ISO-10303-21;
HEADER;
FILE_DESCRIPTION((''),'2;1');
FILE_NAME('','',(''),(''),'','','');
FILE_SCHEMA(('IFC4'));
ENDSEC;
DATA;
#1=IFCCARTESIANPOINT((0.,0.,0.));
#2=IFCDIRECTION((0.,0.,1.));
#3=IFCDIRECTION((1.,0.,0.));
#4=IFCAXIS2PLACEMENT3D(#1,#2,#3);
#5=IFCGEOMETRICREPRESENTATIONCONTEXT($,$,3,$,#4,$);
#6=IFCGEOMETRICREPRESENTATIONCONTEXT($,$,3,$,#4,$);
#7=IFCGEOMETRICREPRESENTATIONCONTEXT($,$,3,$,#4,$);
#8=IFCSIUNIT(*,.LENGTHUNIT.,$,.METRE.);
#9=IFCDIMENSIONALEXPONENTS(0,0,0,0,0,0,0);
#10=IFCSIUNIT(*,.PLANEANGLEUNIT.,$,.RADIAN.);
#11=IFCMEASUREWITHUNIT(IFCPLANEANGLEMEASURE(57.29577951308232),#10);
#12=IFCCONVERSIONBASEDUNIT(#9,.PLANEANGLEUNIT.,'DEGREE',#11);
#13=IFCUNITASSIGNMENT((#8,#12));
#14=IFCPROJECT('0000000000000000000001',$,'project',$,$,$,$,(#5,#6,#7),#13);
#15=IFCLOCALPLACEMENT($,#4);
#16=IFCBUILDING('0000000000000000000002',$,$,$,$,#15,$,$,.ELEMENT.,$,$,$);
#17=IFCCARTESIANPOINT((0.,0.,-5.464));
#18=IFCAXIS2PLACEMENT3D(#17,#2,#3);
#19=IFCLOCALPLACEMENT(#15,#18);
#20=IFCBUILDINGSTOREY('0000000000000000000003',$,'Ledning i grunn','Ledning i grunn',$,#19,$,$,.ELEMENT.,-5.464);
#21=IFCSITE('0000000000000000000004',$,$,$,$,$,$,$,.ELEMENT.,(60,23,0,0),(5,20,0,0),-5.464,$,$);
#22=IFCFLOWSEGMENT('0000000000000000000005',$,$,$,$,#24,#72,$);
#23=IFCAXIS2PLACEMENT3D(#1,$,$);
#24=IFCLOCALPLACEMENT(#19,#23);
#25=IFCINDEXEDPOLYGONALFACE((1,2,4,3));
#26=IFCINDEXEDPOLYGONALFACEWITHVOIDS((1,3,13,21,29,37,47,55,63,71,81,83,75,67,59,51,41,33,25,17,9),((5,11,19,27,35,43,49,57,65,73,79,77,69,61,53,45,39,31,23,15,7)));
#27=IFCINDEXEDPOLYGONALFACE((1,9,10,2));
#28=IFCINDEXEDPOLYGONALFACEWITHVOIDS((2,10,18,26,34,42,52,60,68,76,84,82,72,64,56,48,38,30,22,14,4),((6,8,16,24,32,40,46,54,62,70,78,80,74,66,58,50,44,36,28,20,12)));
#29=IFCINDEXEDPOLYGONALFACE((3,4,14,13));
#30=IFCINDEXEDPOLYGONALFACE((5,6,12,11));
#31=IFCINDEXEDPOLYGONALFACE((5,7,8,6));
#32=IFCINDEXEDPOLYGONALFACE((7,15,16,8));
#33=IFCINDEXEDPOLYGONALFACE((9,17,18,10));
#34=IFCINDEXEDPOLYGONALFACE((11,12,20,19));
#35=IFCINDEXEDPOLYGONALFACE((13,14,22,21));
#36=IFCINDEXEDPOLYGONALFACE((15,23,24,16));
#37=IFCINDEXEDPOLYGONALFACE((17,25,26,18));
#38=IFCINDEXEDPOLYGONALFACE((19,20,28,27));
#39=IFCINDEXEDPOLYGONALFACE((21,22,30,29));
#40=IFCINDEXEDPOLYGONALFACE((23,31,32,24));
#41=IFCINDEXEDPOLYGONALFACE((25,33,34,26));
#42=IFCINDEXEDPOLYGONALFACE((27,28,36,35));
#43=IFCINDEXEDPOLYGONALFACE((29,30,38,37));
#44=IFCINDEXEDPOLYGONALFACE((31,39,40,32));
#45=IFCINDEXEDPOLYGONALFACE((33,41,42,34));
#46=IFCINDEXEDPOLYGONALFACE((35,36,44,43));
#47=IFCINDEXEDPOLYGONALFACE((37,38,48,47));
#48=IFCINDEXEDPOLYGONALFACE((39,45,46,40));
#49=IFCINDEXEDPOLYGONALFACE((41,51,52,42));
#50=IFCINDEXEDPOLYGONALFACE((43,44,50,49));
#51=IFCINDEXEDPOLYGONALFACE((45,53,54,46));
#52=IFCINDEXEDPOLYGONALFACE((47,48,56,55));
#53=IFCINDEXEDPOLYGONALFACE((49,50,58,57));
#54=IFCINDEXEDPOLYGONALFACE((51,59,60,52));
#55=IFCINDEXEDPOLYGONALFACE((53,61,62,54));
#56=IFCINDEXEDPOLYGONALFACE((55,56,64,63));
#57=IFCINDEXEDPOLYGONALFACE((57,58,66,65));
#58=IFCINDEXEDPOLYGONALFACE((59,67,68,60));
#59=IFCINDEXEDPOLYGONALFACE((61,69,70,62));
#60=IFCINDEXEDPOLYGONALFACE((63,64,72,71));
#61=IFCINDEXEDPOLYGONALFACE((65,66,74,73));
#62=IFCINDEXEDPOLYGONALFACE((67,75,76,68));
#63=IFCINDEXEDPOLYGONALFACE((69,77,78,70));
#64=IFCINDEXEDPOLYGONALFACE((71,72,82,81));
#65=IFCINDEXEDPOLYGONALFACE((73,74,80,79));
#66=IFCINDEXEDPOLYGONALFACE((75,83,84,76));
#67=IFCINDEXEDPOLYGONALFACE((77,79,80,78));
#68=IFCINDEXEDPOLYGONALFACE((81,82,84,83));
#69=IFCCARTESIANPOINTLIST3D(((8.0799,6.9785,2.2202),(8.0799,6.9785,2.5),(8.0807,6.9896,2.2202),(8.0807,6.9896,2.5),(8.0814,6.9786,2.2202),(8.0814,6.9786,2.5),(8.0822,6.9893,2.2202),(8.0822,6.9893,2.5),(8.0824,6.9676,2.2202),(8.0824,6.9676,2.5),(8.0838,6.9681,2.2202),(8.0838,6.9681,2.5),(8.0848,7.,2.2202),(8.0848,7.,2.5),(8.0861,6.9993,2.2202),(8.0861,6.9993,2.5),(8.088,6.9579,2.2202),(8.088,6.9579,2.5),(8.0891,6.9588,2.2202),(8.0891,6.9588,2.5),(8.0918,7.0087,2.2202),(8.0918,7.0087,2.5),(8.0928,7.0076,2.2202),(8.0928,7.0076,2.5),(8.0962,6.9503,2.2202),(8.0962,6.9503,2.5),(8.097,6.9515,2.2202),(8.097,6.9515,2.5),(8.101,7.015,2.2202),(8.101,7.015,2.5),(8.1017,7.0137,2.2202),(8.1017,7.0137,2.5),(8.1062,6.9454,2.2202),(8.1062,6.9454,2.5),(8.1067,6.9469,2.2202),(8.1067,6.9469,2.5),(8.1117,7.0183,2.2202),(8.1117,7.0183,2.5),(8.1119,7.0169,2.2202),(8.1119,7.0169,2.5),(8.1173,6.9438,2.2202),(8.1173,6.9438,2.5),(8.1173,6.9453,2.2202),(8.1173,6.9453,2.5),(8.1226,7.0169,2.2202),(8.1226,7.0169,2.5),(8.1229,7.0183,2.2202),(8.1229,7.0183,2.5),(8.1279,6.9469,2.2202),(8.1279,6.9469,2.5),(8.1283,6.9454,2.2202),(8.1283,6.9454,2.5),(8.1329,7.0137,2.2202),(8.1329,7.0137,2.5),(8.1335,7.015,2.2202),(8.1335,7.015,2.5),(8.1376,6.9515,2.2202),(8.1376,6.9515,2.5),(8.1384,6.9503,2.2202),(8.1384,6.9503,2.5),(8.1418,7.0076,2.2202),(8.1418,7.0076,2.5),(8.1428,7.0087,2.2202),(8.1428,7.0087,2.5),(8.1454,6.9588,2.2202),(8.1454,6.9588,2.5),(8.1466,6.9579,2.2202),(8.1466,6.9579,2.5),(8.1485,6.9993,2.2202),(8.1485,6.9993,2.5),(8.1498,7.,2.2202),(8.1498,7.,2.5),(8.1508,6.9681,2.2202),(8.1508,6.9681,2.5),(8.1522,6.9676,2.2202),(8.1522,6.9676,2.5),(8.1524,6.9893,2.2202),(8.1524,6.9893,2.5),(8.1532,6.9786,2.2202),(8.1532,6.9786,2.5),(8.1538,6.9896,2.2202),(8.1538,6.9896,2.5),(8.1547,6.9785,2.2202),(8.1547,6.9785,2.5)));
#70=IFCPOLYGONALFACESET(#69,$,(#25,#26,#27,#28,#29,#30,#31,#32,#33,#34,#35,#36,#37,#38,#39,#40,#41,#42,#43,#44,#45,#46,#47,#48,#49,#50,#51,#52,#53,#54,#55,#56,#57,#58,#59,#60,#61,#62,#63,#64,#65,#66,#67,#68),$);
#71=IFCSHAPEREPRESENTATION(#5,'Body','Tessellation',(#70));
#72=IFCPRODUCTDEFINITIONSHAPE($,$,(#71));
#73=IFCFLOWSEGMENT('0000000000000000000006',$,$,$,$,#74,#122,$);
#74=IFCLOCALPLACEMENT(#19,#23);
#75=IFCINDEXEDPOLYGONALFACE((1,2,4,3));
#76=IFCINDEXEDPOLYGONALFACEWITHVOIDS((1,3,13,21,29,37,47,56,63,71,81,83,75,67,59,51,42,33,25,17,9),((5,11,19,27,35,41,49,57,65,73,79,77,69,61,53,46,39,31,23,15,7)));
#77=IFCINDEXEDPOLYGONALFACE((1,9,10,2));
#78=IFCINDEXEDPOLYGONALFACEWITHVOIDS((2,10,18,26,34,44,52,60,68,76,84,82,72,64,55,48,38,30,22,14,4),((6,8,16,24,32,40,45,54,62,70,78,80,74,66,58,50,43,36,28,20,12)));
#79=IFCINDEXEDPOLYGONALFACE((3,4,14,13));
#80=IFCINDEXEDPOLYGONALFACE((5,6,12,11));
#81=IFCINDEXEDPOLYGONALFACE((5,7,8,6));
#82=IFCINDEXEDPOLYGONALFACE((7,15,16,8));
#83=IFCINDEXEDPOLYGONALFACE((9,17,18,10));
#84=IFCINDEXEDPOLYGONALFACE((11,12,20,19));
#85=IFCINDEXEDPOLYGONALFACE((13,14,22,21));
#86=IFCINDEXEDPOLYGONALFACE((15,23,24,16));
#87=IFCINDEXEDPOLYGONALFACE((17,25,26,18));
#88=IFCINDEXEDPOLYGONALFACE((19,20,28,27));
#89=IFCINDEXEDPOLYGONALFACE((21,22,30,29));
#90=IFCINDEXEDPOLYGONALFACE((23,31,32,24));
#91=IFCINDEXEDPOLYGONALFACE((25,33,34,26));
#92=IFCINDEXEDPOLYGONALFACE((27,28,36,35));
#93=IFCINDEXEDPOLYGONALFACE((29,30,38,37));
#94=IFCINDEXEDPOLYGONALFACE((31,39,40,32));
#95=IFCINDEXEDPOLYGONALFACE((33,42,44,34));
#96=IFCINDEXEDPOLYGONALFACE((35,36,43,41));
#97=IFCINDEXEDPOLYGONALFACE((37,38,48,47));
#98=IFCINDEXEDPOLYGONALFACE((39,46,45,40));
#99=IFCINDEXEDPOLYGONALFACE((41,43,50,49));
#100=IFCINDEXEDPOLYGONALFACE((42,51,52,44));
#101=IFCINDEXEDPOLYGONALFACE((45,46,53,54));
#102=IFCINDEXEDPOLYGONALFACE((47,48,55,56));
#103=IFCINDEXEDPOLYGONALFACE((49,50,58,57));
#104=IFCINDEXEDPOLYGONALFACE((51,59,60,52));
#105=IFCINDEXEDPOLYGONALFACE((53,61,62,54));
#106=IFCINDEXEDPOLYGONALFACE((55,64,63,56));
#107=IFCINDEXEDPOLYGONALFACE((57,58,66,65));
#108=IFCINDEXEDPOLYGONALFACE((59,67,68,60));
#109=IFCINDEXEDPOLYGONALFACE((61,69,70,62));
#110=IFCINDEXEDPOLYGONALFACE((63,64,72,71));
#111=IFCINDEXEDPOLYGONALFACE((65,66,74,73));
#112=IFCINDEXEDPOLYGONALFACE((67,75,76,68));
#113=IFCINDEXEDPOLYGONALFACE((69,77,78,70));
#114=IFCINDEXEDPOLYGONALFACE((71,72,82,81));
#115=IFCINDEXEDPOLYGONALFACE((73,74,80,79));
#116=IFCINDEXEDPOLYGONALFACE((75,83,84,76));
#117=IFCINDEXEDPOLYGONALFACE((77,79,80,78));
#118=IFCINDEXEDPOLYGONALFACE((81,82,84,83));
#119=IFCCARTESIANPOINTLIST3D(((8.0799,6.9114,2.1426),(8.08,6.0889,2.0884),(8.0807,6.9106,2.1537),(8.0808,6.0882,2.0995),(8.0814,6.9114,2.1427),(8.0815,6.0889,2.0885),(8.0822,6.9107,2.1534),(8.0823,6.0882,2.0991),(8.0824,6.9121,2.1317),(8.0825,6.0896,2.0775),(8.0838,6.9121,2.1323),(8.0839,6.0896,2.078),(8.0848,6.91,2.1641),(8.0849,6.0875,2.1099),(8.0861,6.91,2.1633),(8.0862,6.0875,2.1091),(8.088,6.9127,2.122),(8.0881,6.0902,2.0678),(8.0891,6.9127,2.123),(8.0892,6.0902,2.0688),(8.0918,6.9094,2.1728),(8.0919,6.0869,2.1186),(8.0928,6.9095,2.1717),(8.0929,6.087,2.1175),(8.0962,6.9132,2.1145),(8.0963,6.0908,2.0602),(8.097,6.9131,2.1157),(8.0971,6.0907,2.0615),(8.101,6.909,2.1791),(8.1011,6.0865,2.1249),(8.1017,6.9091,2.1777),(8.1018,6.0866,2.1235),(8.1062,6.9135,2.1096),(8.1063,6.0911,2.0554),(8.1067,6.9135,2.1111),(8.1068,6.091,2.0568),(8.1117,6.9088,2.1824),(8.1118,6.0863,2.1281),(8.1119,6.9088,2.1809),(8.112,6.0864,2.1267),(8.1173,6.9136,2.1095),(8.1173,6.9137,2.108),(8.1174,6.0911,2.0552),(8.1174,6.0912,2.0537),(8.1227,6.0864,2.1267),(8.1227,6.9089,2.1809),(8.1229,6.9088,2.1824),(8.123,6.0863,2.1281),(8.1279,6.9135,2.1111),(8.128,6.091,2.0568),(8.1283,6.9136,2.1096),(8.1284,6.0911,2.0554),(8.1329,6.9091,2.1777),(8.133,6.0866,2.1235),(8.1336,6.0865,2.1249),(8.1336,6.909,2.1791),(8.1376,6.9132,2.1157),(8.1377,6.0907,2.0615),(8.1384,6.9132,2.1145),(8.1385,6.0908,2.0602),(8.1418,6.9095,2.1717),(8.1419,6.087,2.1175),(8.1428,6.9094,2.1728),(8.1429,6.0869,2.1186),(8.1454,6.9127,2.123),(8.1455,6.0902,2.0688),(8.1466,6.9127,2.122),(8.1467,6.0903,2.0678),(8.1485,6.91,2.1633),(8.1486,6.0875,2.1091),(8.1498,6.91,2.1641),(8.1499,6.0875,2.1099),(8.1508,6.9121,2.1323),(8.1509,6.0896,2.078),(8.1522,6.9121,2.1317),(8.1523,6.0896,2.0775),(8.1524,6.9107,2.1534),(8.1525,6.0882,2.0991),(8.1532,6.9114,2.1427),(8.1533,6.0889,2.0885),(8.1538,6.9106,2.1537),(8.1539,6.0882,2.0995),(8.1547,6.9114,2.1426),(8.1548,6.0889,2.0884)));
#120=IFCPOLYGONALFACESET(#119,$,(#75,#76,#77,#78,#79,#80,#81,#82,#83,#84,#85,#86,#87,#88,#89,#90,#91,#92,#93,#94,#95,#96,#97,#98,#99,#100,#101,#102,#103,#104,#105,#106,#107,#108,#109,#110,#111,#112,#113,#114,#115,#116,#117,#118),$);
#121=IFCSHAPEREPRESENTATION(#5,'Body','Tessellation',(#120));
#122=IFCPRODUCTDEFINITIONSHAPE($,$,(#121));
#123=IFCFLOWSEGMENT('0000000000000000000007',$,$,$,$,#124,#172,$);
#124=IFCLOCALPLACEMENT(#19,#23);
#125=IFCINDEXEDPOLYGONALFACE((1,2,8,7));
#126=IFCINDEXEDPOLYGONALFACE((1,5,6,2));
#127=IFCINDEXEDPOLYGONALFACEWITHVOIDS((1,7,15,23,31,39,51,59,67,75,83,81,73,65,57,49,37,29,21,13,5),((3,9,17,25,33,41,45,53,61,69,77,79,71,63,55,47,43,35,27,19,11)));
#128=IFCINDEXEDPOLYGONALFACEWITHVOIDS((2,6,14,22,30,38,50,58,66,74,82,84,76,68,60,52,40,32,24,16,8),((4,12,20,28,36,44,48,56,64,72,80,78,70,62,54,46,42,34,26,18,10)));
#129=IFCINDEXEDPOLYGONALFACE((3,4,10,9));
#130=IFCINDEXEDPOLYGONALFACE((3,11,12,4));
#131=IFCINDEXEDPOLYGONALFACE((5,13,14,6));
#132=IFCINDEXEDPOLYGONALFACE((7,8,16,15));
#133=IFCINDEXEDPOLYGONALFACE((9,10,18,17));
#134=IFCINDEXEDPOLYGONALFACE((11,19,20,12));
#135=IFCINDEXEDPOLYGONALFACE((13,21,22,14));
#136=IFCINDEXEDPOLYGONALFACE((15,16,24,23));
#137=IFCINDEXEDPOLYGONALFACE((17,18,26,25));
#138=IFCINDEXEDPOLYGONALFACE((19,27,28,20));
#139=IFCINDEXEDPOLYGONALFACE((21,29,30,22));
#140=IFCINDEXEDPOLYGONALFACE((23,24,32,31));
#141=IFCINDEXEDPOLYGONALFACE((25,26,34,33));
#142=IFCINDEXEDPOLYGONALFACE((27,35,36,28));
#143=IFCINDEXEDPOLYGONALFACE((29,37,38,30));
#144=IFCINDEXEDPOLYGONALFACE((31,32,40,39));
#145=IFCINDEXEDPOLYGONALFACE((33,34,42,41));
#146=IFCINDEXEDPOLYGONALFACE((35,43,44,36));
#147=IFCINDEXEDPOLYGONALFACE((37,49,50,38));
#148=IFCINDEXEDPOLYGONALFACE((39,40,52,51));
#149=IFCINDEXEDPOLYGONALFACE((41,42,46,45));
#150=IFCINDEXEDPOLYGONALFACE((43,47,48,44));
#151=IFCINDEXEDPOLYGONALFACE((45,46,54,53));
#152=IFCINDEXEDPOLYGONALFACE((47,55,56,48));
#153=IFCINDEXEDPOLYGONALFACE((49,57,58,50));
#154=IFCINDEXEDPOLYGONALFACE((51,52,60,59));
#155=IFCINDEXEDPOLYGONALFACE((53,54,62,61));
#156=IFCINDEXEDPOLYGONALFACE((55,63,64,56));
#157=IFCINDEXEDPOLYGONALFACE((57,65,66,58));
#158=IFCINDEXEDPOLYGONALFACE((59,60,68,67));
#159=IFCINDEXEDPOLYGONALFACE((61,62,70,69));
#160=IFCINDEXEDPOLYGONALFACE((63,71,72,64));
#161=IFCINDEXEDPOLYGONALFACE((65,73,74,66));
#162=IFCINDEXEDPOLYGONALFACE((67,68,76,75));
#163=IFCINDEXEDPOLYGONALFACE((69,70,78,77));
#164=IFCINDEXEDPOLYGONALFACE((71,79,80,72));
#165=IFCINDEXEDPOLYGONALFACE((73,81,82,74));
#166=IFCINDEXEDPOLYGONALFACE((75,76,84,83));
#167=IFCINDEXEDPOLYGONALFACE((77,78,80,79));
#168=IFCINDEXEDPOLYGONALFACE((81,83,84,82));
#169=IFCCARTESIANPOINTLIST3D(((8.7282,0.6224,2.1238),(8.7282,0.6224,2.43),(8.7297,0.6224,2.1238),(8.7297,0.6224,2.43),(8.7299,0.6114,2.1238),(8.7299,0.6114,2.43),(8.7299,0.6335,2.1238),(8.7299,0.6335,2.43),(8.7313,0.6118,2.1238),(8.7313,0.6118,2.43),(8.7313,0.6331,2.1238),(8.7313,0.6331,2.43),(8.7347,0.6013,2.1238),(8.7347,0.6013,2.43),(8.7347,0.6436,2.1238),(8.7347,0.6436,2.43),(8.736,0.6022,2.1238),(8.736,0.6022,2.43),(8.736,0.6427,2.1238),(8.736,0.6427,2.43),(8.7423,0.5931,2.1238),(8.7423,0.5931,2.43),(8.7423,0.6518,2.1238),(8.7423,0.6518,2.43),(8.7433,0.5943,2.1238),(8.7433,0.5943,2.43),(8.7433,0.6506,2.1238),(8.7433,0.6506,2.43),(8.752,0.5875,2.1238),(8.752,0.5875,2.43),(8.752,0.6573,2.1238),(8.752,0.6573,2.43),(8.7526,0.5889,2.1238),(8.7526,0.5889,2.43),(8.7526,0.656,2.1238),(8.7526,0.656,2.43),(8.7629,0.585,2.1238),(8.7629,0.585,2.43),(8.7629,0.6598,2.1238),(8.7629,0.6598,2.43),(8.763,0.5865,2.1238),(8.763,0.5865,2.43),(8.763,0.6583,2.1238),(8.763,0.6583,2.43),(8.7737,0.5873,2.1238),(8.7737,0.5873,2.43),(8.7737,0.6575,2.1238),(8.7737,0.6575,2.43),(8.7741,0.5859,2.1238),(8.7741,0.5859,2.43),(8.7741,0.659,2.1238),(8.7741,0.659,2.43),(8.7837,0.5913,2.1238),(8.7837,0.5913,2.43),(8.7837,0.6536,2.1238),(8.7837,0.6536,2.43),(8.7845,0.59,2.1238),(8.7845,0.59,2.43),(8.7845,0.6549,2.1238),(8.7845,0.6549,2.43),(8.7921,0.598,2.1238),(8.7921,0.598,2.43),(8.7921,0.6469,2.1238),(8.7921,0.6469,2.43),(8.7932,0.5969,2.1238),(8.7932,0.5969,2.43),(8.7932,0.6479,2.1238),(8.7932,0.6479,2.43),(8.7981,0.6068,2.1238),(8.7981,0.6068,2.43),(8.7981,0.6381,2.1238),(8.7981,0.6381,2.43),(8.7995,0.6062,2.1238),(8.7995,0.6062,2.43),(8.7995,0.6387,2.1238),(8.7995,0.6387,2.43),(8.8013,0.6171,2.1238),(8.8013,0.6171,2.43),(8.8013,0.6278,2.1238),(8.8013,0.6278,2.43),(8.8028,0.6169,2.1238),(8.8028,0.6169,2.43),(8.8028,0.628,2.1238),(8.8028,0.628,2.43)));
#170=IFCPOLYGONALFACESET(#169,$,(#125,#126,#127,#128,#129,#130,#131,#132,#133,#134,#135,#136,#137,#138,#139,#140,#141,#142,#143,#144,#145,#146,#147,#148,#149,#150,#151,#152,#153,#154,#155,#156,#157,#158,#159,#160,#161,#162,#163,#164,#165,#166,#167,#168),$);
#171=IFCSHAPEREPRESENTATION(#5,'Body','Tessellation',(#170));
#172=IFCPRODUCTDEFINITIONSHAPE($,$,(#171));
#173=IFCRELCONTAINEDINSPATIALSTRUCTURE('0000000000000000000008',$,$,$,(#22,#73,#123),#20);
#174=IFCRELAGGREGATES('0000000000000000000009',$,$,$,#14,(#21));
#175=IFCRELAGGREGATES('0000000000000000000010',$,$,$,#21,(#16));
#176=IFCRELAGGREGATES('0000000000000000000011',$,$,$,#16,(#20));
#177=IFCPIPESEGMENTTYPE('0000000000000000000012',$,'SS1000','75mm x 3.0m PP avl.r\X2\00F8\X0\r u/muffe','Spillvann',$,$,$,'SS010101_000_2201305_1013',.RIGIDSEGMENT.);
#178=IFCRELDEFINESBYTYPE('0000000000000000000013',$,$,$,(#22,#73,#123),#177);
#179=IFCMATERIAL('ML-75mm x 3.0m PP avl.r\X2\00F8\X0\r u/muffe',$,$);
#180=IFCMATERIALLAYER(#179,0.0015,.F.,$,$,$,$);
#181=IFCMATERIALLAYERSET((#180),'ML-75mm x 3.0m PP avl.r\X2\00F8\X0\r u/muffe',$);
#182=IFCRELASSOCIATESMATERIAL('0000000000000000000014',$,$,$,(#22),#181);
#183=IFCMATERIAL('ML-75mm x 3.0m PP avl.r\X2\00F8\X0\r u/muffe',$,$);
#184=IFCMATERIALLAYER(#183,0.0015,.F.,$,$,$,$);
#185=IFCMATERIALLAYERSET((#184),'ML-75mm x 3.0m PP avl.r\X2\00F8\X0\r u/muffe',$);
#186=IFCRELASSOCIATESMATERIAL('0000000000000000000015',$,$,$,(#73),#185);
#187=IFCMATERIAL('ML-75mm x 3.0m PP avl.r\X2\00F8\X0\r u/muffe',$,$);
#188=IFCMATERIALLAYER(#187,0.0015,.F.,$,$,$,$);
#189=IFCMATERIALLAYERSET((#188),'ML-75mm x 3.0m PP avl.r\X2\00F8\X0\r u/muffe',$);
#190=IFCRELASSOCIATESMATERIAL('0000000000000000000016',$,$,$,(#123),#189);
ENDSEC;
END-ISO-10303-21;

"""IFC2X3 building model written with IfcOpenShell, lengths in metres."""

from ifc_helpers import new_model, entity, si_unit, converted_unit, frame, origin_with_axes, origin_2d_with_axis, place, context, project, spatial, hollow_circle, extrude, material, layer, layer_set, layer_usage, type_object, element, save


model = new_model("IFC2X3")

# Units and contexts
context_of_model_1 = context(None, 3, world=origin_with_axes())
context_of_model_2 = context(None, 3, world=origin_with_axes())
context_of_model_3 = context(None, 3, world=origin_with_axes())
ifc_project = project(units=[si_unit("LENGTHUNIT", "METRE"), converted_unit("PLANEANGLEUNIT", "DEGREE", entity("IfcPlaneAngleMeasure", 57.29577951308232), si_unit("PLANEANGLEUNIT", "RADIAN"), dimensions=[0, 0, 0, 0, 0, 0, 0])], contexts=[context_of_model_1, context_of_model_2, context_of_model_3])

# Site, building, storey
site = spatial("IfcSite", under=ifc_project, CompositionType="ELEMENT", RefLatitude=(60, 23, 0, 0), RefLongitude=(5, 20, 0, 0), RefElevation=-5.464)
building_placement = place(None, origin_with_axes())
building = spatial("IfcBuilding", under=site, at=building_placement, CompositionType="ELEMENT")
storey_placement = place(building_placement, frame((0.0, 0.0, -5.464), z_axis=(0.0, 0.0, 1.0), x_axis=(1.0, 0.0, 0.0)))
storey = spatial("IfcBuildingStorey", under=building, at=storey_placement, Name="Ledning i grunn", Description="Ledning i grunn", CompositionType="ELEMENT", Elevation=-5.464)

# Flow segments
ifc_material_1 = material(Name="ML-75mm x 3.0m PP avl.rør u/muffe")
ifc_layer_1 = layer(ifc_material_1, 0.0015, ventilated=False)
ifc_layer_set_1 = layer_set([ifc_layer_1], Name="ML-75mm x 3.0m PP avl.rør u/muffe")
ifc_layer_usage_1 = layer_usage(ifc_layer_set_1, "AXIS2", "POSITIVE", 0.0)
pipe_segment_type_1 = type_object("IfcPipeSegmentType", Name="SS1000", Description="75mm x 3.0m PP avl.rør u/muffe", ApplicableOccurrence="Spillvann", ElementType="SS010101_000_2201305_1013", PredefinedType="RIGIDSEGMENT")
flow_segment_1_placement = place(storey_placement, frame((8.1173, 6.9813, 2.5), z_axis=(0.0, 0.0, -1.0), x_axis=(0.0, -1.0, 0.0)))
element("IfcFlowSegment", 1, at=flow_segment_1_placement, inside=storey, type_object=pipe_segment_type_1, material=ifc_layer_usage_1, context=context_of_model_1, shape_type="SweptSolid", body=[
    extrude(hollow_circle(Radius=0.0375, WallThickness=0.0015, at=origin_2d_with_axis()), origin_with_axes(), (0.0, 0.0, 1.0), 0.2798),
])
ifc_material_2 = material(Name="ML-75mm x 3.0m PP avl.rør u/muffe")
ifc_layer_2 = layer(ifc_material_2, 0.0015, ventilated=False)
ifc_layer_set_2 = layer_set([ifc_layer_2], Name="ML-75mm x 3.0m PP avl.rør u/muffe")
ifc_layer_usage_2 = layer_usage(ifc_layer_set_2, "AXIS2", "POSITIVE", 0.0)
flow_segment_2_placement = place(storey_placement, frame((8.1173, 6.9112, 2.1454), z_axis=(0.000109, -0.997833, -0.065795), x_axis=(-0.000007, 0.065795, -0.997833)))
element("IfcFlowSegment", 2, at=flow_segment_2_placement, inside=storey, type_object=pipe_segment_type_1, material=ifc_layer_usage_2, context=context_of_model_1, shape_type="SweptSolid", body=[
    extrude(hollow_circle(Radius=0.0375, WallThickness=0.0015, at=origin_2d_with_axis()), origin_with_axes(), (0.0, 0.0, 1.0), 0.8243),
])
ifc_material_3 = material(Name="ML-75mm x 3.0m PP avl.rør u/muffe")
ifc_layer_3 = layer(ifc_material_3, 0.0015, ventilated=False)
ifc_layer_set_3 = layer_set([ifc_layer_3], Name="ML-75mm x 3.0m PP avl.rør u/muffe")
ifc_layer_usage_3 = layer_usage(ifc_layer_set_3, "AXIS2", "POSITIVE", 0.0)
flow_segment_3_placement = place(storey_placement, frame((8.7657, 0.6224, 2.43), z_axis=(0.0, 0.0, -1.0), x_axis=(-1.0, 0.0, 0.0)))
element("IfcFlowSegment", 3, at=flow_segment_3_placement, inside=storey, type_object=pipe_segment_type_1, material=ifc_layer_usage_3, context=context_of_model_1, shape_type="SweptSolid", body=[
    extrude(hollow_circle(Radius=0.0375, WallThickness=0.0015, at=origin_2d_with_axis()), origin_with_axes(), (0.0, 0.0, 1.0), 0.3062),
])

save(model, "model.ifc")
